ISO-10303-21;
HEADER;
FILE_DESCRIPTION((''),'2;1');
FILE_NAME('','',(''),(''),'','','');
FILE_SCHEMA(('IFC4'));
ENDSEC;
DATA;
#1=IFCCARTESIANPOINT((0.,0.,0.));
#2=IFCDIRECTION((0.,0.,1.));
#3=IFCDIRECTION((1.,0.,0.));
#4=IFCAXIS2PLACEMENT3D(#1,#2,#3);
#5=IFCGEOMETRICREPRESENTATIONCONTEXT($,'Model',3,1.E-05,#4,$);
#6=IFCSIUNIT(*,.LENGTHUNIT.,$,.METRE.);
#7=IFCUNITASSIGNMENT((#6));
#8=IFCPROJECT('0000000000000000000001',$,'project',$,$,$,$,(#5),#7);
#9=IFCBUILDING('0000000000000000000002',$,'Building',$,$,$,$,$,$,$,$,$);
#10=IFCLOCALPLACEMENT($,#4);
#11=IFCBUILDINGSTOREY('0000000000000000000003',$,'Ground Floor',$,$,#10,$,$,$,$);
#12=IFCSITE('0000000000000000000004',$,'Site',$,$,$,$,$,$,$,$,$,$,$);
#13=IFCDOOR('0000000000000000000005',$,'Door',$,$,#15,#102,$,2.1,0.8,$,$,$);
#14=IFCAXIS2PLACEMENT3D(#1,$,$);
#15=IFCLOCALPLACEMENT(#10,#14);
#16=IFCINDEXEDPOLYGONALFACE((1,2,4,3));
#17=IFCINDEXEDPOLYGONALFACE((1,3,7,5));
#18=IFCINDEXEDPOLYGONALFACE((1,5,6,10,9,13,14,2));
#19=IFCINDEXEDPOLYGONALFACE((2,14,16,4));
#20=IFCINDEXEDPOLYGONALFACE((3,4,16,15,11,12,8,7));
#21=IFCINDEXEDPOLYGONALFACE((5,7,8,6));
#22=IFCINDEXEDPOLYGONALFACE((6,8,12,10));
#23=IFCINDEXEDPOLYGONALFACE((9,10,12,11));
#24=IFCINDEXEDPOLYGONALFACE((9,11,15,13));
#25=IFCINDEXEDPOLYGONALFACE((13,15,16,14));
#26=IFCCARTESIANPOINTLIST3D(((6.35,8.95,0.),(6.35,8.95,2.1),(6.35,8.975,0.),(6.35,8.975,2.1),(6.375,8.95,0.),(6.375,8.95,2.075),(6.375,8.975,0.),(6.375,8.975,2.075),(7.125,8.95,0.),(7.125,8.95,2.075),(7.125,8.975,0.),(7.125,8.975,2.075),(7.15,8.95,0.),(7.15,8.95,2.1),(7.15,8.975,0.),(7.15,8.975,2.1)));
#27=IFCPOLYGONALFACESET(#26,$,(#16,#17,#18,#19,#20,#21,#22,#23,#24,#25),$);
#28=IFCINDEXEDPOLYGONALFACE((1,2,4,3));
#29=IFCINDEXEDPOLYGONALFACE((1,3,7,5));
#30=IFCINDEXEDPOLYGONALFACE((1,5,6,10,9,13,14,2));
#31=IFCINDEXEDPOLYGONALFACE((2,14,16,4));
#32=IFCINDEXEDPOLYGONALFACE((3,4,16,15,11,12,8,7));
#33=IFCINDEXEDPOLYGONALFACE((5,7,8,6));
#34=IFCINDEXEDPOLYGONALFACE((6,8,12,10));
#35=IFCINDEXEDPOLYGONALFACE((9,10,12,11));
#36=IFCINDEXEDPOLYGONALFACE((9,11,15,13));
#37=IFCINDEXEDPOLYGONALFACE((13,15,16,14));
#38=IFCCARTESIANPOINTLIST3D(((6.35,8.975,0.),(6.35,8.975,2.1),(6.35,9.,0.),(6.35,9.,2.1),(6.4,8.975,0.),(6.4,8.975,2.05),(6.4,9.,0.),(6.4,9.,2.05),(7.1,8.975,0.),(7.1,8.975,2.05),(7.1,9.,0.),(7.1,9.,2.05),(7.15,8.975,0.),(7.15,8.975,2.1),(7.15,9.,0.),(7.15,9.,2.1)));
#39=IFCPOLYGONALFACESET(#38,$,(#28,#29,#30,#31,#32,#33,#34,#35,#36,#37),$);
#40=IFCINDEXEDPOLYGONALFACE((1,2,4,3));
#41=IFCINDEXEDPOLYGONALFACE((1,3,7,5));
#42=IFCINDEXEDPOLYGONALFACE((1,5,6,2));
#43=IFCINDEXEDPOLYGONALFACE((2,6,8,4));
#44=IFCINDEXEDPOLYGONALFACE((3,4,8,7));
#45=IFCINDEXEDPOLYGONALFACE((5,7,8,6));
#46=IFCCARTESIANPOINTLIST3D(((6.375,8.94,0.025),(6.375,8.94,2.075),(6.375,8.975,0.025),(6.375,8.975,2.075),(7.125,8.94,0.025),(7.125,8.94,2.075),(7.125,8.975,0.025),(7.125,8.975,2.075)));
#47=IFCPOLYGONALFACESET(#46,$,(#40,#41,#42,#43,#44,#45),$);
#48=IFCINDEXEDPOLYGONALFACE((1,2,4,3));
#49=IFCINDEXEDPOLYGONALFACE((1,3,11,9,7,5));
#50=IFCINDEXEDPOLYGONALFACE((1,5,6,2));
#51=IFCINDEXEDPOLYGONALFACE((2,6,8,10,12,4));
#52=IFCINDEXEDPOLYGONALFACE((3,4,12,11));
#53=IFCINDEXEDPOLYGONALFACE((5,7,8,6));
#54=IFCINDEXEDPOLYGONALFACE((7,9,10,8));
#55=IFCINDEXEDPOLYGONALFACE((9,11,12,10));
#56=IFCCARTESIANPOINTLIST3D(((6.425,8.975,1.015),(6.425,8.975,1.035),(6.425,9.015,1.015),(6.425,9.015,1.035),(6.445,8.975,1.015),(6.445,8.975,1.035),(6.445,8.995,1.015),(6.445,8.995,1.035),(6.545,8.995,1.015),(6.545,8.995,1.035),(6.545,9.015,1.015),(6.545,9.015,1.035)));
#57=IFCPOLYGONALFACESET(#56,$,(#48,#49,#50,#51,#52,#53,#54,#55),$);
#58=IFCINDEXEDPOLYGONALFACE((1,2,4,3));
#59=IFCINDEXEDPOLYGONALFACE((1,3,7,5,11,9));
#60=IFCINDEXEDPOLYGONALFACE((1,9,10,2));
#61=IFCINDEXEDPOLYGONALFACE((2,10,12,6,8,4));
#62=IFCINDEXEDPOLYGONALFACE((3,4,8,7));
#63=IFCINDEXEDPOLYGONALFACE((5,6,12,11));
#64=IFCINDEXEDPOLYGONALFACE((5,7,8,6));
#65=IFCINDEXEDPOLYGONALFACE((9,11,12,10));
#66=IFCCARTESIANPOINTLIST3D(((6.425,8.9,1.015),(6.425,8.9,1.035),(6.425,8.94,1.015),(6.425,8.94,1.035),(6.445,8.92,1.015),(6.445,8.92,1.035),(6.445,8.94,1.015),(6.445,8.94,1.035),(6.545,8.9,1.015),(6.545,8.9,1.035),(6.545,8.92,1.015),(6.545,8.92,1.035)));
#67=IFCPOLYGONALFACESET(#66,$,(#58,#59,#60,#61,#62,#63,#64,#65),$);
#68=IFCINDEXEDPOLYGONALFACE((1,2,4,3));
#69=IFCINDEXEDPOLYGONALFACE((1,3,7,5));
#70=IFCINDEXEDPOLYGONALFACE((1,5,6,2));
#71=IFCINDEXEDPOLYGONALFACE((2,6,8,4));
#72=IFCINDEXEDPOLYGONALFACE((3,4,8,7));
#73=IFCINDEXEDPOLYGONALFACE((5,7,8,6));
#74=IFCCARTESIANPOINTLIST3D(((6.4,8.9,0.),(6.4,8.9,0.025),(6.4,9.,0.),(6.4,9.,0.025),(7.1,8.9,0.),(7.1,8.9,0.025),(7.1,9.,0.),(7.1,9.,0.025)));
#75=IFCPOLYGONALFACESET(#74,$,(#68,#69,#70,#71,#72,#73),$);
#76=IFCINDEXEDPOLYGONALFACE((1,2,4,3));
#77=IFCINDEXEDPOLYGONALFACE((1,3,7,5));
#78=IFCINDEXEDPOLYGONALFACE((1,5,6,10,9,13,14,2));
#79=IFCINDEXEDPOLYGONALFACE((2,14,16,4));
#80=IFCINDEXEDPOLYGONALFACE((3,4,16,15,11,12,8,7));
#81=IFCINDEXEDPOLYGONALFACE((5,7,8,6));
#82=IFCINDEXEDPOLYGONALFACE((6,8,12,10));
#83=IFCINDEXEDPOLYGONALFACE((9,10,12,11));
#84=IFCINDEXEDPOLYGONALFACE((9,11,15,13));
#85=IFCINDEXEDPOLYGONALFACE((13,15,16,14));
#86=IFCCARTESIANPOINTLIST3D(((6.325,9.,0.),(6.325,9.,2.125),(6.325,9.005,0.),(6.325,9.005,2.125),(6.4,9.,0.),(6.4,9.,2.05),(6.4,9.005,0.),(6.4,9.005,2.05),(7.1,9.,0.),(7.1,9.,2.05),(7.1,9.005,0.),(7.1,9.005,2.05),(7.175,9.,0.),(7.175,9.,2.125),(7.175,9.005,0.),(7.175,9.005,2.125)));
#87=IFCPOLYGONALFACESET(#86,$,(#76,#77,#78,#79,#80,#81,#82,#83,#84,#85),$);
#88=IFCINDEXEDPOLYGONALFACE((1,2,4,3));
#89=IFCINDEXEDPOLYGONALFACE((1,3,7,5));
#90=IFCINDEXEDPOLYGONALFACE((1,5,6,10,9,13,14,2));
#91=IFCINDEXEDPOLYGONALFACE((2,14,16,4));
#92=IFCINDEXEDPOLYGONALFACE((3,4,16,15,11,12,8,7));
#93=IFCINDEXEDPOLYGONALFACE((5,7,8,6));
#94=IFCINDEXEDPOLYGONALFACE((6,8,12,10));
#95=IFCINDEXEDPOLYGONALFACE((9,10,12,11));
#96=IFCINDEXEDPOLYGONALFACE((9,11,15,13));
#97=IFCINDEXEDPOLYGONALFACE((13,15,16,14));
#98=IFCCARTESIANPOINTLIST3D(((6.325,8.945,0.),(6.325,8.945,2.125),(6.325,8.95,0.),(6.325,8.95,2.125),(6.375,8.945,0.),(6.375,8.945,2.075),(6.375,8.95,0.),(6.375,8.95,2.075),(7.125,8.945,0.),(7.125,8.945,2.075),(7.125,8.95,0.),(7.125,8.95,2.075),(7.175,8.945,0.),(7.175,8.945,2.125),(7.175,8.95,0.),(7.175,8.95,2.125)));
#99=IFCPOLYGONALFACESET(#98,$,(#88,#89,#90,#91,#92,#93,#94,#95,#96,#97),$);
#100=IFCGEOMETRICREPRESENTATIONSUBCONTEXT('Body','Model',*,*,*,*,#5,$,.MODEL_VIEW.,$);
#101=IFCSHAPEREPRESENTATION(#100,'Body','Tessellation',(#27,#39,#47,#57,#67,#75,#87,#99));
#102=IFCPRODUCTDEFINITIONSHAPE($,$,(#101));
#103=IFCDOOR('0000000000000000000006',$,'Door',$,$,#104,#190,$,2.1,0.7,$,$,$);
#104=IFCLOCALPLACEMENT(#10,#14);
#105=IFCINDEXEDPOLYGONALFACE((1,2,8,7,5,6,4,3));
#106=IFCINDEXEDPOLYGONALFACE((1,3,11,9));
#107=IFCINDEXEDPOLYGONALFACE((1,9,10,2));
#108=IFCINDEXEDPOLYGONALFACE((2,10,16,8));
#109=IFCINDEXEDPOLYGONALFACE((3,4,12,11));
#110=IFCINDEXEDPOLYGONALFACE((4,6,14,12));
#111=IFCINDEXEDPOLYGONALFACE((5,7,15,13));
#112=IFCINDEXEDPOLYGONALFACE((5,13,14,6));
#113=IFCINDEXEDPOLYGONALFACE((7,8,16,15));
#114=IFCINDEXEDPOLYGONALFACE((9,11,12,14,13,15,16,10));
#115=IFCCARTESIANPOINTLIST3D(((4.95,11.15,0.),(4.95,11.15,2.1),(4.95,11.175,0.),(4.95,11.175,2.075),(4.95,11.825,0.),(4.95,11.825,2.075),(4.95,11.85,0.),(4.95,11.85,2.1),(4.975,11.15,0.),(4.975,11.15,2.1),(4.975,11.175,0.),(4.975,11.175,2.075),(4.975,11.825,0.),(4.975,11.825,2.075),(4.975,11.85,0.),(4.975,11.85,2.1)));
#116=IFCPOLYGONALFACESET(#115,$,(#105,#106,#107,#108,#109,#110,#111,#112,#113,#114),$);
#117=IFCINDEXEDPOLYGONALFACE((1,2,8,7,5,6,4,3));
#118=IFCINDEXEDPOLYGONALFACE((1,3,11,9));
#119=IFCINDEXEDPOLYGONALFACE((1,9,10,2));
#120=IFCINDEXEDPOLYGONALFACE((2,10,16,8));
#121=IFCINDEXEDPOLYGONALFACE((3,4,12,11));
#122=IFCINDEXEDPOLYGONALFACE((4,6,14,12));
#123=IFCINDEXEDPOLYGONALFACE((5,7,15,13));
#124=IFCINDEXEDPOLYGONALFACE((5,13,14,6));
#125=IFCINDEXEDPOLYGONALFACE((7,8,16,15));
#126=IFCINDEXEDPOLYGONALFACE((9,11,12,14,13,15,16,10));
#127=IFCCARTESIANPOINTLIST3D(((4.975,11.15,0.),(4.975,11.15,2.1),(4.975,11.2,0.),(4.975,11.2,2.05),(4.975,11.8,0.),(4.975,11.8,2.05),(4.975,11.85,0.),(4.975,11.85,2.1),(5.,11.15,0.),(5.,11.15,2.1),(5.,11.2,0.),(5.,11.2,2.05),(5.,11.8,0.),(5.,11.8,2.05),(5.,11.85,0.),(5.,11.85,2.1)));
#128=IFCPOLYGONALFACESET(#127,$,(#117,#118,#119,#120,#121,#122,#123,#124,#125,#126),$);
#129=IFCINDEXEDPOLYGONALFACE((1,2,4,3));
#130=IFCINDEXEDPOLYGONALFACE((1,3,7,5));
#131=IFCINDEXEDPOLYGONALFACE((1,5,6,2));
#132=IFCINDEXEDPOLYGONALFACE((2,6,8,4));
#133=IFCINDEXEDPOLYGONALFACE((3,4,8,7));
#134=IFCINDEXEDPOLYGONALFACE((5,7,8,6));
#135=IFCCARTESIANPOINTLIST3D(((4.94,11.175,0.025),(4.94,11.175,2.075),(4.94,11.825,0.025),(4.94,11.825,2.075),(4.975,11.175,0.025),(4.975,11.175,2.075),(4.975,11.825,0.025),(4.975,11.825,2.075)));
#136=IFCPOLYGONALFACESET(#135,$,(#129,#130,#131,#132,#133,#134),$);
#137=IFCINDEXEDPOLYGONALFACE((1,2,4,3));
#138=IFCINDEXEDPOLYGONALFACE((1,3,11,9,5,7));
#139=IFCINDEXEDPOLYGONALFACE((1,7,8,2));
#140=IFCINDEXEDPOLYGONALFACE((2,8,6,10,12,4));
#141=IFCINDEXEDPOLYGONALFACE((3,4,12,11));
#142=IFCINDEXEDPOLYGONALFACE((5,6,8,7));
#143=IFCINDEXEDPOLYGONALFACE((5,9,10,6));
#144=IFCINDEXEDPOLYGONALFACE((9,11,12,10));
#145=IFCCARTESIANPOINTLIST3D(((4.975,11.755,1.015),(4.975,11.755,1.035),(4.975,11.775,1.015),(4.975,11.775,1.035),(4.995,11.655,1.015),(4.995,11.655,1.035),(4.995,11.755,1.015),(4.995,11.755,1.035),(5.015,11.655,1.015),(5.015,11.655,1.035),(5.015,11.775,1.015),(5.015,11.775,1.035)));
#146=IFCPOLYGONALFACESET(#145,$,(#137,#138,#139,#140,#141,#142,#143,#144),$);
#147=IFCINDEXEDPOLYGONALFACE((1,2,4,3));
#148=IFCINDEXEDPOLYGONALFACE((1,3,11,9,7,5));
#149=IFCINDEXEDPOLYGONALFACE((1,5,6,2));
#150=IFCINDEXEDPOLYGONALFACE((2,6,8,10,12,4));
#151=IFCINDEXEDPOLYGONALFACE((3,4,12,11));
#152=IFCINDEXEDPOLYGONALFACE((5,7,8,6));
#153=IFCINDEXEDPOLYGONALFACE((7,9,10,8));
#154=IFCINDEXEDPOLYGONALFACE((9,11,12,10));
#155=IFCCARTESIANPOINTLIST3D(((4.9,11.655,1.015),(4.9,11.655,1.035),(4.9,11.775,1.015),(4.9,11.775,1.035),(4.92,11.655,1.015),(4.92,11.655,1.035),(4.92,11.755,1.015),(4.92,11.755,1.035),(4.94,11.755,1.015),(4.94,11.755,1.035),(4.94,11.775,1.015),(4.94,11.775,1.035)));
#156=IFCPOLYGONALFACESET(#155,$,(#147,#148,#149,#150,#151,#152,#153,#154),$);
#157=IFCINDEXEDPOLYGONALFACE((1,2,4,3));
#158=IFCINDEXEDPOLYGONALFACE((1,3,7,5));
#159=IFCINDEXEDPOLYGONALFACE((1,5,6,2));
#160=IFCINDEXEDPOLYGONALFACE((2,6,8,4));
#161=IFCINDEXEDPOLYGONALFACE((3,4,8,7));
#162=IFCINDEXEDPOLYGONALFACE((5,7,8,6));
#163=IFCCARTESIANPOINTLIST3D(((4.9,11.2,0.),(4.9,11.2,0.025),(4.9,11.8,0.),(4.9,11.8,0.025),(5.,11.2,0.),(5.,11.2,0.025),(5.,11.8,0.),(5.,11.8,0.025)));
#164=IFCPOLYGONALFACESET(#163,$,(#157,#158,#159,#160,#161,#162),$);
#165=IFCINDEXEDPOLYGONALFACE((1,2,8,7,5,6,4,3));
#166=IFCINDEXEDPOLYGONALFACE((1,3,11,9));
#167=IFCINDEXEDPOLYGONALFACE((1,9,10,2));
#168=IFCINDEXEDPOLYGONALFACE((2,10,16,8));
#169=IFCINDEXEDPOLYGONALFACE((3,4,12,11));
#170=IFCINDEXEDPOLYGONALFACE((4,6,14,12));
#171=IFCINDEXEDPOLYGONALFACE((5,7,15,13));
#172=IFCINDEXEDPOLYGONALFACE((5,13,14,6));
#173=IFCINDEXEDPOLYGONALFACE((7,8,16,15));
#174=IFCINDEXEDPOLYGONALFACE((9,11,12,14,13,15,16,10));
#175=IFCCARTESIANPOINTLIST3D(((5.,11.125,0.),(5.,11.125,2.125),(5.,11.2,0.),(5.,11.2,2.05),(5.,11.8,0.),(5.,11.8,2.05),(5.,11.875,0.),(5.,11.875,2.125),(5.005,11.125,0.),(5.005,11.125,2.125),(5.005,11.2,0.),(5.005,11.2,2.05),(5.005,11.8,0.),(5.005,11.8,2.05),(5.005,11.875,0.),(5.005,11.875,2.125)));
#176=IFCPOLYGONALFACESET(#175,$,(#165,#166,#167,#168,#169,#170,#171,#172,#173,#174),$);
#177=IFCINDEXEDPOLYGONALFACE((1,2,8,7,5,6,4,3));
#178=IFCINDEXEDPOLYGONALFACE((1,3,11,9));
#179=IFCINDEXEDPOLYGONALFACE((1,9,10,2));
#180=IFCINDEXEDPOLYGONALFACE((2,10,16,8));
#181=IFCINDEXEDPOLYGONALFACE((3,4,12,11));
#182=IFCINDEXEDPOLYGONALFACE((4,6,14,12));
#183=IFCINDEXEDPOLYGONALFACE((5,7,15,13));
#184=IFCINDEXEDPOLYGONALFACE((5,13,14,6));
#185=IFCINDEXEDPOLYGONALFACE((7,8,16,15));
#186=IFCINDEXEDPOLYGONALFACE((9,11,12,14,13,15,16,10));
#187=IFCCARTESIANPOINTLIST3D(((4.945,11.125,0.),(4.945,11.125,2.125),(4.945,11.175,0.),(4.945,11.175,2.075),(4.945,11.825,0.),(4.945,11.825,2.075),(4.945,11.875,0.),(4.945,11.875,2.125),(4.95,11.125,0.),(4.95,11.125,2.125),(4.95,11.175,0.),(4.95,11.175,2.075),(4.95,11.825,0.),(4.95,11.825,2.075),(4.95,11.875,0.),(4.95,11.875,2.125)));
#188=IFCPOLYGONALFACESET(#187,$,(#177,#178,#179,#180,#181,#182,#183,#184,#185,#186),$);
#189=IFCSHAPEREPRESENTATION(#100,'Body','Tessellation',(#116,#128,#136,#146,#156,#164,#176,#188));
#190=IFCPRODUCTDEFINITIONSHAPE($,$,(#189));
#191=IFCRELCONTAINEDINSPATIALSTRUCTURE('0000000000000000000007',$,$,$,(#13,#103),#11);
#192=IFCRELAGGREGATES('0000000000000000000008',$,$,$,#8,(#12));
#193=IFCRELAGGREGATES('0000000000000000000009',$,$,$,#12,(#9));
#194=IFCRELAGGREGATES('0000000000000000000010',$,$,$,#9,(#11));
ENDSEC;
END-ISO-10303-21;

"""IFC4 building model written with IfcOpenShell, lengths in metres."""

from ifc_helpers import new_model, si_unit, frame, origin_with_axes, place, context, subcontext, project, spatial, line, indexed_curve, outline, extrude, element, save


model = new_model("IFC4")

# Units and contexts
model_context = context("Model", 3, precision=1e-05, world=origin_with_axes())
body_context = subcontext(model_context, "Body", "Model", "MODEL_VIEW")
ifc_project = project(units=[si_unit("LENGTHUNIT", "METRE")], contexts=[model_context])

# Site, building, storey
site = spatial("IfcSite", under=ifc_project, Name="Site")
building = spatial("IfcBuilding", under=site, Name="Building")
storey_placement = place(None, origin_with_axes())
storey = spatial("IfcBuildingStorey", under=building, at=storey_placement, Name="Ground Floor")

# Doors
door_1_placement = place(storey_placement, frame((7.15, 9.0, 0.0), z_axis=(0.0, 0.0, 1.0), x_axis=(-1.0, 0.0, 0.0)))
element("IfcDoor", 1, at=door_1_placement, inside=storey, Name="Door", OverallHeight=2.1, OverallWidth=0.8, context=body_context, shape_type="SweptSolid", body=[
    extrude(outline(indexed_curve([(0.0, 0.0), (0.0, 2.1), (0.8, 2.1), (0.8, 0.0), (0.775, 0.0), (0.775, 2.075), (0.025, 2.075), (0.025, 0.0)], segments=[line(1, 2, 3, 4, 5, 6, 7, 8, 1)])), frame((0.0, 0.025, 0.0), z_axis=(0.0, -1.0, 0.0), x_axis=(1.0, 0.0, 0.0)), (0.0, 0.0, -1.0), 0.025),
    extrude(outline(indexed_curve([(0.0, 0.0), (0.0, 2.1), (0.8, 2.1), (0.8, 0.0), (0.75, 0.0), (0.75, 2.05), (0.05, 2.05), (0.05, 0.0)], segments=[line(1, 2, 3, 4, 5, 6, 7, 8, 1)])), frame((0.0, 0.0, 0.0), z_axis=(0.0, -1.0, 0.0), x_axis=(1.0, 0.0, 0.0)), (0.0, 0.0, -1.0), 0.025),
    extrude(outline(indexed_curve([(0.0, 0.0), (0.75, 0.0), (0.75, 0.035), (0.0, 0.035)], segments=[line(1, 2, 3, 4, 1)])), frame((0.025, 0.025, 0.025), z_axis=(0.0, 0.0, 1.0), x_axis=(1.0, 0.0, 0.0)), (0.0, 0.0, 1.0), 2.05),
    extrude(outline(indexed_curve([(0.0, 0.0), (0.0, -0.04), (-0.12, -0.04), (-0.12, -0.02), (-0.02, -0.02), (-0.02, 0.0)], segments=[line(1, 2, 3, 4, 5, 6, 1)])), frame((0.725, 0.025, 1.015), z_axis=(0.0, 0.0, 1.0), x_axis=(1.0, 0.0, 0.0)), (0.0, 0.0, 1.0), 0.02),
    extrude(outline(indexed_curve([(0.0, 0.0), (0.0, 0.04), (-0.12, 0.04), (-0.12, 0.02), (-0.02, 0.02), (-0.02, 0.0)], segments=[line(1, 2, 3, 4, 5, 6, 1)])), frame((0.725, 0.06, 1.015), z_axis=(0.0, 0.0, 1.0), x_axis=(1.0, 0.0, 0.0)), (0.0, 0.0, 1.0), 0.02),
    extrude(outline(indexed_curve([(0.0, 0.0), (0.7, 0.0), (0.7, 0.1), (0.0, 0.1)], segments=[line(1, 2, 3, 4, 1)])), frame((0.05, 0.0, 0.0), z_axis=(0.0, 0.0, 1.0), x_axis=(1.0, 0.0, 0.0)), (0.0, 0.0, 1.0), 0.025),
    extrude(outline(indexed_curve([(0.0, 0.0), (0.0, 2.125), (0.85, 2.125), (0.85, 0.0), (0.775, 0.0), (0.775, 2.05), (0.075, 2.05), (0.075, 0.0)], segments=[line(1, 2, 3, 4, 5, 6, 7, 8, 1)])), frame((-0.025, -0.005, 0.0), z_axis=(0.0, -1.0, 0.0), x_axis=(1.0, 0.0, 0.0)), (0.0, 0.0, -1.0), 0.005),
    extrude(outline(indexed_curve([(0.0, 0.0), (0.0, 2.125), (0.85, 2.125), (0.85, 0.0), (0.8, 0.0), (0.8, 2.075), (0.05, 2.075), (0.05, 0.0)], segments=[line(1, 2, 3, 4, 5, 6, 7, 8, 1)])), frame((-0.025, 0.05, 0.0), z_axis=(0.0, -1.0, 0.0), x_axis=(1.0, 0.0, 0.0)), (0.0, 0.0, -1.0), 0.005),
])
door_2_placement = place(storey_placement, frame((5.0, 11.15, 0.0), z_axis=(0.0, 0.0, 1.0), x_axis=(0.0, 1.0, 0.0)))
element("IfcDoor", 2, at=door_2_placement, inside=storey, Name="Door", OverallHeight=2.1, OverallWidth=0.7, context=body_context, shape_type="SweptSolid", body=[
    extrude(outline(indexed_curve([(0.0, 0.0), (0.0, 2.1), (0.7, 2.1), (0.7, 0.0), (0.675, 0.0), (0.675, 2.075), (0.025, 2.075), (0.025, 0.0)], segments=[line(1, 2, 3, 4, 5, 6, 7, 8, 1)])), frame((0.0, 0.025, 0.0), z_axis=(0.0, -1.0, 0.0), x_axis=(1.0, 0.0, 0.0)), (0.0, 0.0, -1.0), 0.025),
    extrude(outline(indexed_curve([(0.0, 0.0), (0.0, 2.1), (0.7, 2.1), (0.7, 0.0), (0.65, 0.0), (0.65, 2.05), (0.05, 2.05), (0.05, 0.0)], segments=[line(1, 2, 3, 4, 5, 6, 7, 8, 1)])), frame((0.0, 0.0, 0.0), z_axis=(0.0, -1.0, 0.0), x_axis=(1.0, 0.0, 0.0)), (0.0, 0.0, -1.0), 0.025),
    extrude(outline(indexed_curve([(0.0, 0.0), (0.65, 0.0), (0.65, 0.035), (0.0, 0.035)], segments=[line(1, 2, 3, 4, 1)])), frame((0.025, 0.025, 0.025), z_axis=(0.0, 0.0, 1.0), x_axis=(1.0, 0.0, 0.0)), (0.0, 0.0, 1.0), 2.05),
    extrude(outline(indexed_curve([(0.0, 0.0), (0.0, -0.04), (-0.12, -0.04), (-0.12, -0.02), (-0.02, -0.02), (-0.02, 0.0)], segments=[line(1, 2, 3, 4, 5, 6, 1)])), frame((0.625, 0.025, 1.015), z_axis=(0.0, 0.0, 1.0), x_axis=(1.0, 0.0, 0.0)), (0.0, 0.0, 1.0), 0.02),
    extrude(outline(indexed_curve([(0.0, 0.0), (0.0, 0.04), (-0.12, 0.04), (-0.12, 0.02), (-0.02, 0.02), (-0.02, 0.0)], segments=[line(1, 2, 3, 4, 5, 6, 1)])), frame((0.625, 0.06, 1.015), z_axis=(0.0, 0.0, 1.0), x_axis=(1.0, 0.0, 0.0)), (0.0, 0.0, 1.0), 0.02),
    extrude(outline(indexed_curve([(0.0, 0.0), (0.6, 0.0), (0.6, 0.1), (0.0, 0.1)], segments=[line(1, 2, 3, 4, 1)])), frame((0.05, 0.0, 0.0), z_axis=(0.0, 0.0, 1.0), x_axis=(1.0, 0.0, 0.0)), (0.0, 0.0, 1.0), 0.025),
    extrude(outline(indexed_curve([(0.0, 0.0), (0.0, 2.125), (0.75, 2.125), (0.75, 0.0), (0.675, 0.0), (0.675, 2.05), (0.075, 2.05), (0.075, 0.0)], segments=[line(1, 2, 3, 4, 5, 6, 7, 8, 1)])), frame((-0.025, -0.005, 0.0), z_axis=(0.0, -1.0, 0.0), x_axis=(1.0, 0.0, 0.0)), (0.0, 0.0, -1.0), 0.005),
    extrude(outline(indexed_curve([(0.0, 0.0), (0.0, 2.125), (0.75, 2.125), (0.75, 0.0), (0.7, 0.0), (0.7, 2.075), (0.05, 2.075), (0.05, 0.0)], segments=[line(1, 2, 3, 4, 5, 6, 7, 8, 1)])), frame((-0.025, 0.05, 0.0), z_axis=(0.0, -1.0, 0.0), x_axis=(1.0, 0.0, 0.0)), (0.0, 0.0, -1.0), 0.005),
])

save(model, "model.ifc")
